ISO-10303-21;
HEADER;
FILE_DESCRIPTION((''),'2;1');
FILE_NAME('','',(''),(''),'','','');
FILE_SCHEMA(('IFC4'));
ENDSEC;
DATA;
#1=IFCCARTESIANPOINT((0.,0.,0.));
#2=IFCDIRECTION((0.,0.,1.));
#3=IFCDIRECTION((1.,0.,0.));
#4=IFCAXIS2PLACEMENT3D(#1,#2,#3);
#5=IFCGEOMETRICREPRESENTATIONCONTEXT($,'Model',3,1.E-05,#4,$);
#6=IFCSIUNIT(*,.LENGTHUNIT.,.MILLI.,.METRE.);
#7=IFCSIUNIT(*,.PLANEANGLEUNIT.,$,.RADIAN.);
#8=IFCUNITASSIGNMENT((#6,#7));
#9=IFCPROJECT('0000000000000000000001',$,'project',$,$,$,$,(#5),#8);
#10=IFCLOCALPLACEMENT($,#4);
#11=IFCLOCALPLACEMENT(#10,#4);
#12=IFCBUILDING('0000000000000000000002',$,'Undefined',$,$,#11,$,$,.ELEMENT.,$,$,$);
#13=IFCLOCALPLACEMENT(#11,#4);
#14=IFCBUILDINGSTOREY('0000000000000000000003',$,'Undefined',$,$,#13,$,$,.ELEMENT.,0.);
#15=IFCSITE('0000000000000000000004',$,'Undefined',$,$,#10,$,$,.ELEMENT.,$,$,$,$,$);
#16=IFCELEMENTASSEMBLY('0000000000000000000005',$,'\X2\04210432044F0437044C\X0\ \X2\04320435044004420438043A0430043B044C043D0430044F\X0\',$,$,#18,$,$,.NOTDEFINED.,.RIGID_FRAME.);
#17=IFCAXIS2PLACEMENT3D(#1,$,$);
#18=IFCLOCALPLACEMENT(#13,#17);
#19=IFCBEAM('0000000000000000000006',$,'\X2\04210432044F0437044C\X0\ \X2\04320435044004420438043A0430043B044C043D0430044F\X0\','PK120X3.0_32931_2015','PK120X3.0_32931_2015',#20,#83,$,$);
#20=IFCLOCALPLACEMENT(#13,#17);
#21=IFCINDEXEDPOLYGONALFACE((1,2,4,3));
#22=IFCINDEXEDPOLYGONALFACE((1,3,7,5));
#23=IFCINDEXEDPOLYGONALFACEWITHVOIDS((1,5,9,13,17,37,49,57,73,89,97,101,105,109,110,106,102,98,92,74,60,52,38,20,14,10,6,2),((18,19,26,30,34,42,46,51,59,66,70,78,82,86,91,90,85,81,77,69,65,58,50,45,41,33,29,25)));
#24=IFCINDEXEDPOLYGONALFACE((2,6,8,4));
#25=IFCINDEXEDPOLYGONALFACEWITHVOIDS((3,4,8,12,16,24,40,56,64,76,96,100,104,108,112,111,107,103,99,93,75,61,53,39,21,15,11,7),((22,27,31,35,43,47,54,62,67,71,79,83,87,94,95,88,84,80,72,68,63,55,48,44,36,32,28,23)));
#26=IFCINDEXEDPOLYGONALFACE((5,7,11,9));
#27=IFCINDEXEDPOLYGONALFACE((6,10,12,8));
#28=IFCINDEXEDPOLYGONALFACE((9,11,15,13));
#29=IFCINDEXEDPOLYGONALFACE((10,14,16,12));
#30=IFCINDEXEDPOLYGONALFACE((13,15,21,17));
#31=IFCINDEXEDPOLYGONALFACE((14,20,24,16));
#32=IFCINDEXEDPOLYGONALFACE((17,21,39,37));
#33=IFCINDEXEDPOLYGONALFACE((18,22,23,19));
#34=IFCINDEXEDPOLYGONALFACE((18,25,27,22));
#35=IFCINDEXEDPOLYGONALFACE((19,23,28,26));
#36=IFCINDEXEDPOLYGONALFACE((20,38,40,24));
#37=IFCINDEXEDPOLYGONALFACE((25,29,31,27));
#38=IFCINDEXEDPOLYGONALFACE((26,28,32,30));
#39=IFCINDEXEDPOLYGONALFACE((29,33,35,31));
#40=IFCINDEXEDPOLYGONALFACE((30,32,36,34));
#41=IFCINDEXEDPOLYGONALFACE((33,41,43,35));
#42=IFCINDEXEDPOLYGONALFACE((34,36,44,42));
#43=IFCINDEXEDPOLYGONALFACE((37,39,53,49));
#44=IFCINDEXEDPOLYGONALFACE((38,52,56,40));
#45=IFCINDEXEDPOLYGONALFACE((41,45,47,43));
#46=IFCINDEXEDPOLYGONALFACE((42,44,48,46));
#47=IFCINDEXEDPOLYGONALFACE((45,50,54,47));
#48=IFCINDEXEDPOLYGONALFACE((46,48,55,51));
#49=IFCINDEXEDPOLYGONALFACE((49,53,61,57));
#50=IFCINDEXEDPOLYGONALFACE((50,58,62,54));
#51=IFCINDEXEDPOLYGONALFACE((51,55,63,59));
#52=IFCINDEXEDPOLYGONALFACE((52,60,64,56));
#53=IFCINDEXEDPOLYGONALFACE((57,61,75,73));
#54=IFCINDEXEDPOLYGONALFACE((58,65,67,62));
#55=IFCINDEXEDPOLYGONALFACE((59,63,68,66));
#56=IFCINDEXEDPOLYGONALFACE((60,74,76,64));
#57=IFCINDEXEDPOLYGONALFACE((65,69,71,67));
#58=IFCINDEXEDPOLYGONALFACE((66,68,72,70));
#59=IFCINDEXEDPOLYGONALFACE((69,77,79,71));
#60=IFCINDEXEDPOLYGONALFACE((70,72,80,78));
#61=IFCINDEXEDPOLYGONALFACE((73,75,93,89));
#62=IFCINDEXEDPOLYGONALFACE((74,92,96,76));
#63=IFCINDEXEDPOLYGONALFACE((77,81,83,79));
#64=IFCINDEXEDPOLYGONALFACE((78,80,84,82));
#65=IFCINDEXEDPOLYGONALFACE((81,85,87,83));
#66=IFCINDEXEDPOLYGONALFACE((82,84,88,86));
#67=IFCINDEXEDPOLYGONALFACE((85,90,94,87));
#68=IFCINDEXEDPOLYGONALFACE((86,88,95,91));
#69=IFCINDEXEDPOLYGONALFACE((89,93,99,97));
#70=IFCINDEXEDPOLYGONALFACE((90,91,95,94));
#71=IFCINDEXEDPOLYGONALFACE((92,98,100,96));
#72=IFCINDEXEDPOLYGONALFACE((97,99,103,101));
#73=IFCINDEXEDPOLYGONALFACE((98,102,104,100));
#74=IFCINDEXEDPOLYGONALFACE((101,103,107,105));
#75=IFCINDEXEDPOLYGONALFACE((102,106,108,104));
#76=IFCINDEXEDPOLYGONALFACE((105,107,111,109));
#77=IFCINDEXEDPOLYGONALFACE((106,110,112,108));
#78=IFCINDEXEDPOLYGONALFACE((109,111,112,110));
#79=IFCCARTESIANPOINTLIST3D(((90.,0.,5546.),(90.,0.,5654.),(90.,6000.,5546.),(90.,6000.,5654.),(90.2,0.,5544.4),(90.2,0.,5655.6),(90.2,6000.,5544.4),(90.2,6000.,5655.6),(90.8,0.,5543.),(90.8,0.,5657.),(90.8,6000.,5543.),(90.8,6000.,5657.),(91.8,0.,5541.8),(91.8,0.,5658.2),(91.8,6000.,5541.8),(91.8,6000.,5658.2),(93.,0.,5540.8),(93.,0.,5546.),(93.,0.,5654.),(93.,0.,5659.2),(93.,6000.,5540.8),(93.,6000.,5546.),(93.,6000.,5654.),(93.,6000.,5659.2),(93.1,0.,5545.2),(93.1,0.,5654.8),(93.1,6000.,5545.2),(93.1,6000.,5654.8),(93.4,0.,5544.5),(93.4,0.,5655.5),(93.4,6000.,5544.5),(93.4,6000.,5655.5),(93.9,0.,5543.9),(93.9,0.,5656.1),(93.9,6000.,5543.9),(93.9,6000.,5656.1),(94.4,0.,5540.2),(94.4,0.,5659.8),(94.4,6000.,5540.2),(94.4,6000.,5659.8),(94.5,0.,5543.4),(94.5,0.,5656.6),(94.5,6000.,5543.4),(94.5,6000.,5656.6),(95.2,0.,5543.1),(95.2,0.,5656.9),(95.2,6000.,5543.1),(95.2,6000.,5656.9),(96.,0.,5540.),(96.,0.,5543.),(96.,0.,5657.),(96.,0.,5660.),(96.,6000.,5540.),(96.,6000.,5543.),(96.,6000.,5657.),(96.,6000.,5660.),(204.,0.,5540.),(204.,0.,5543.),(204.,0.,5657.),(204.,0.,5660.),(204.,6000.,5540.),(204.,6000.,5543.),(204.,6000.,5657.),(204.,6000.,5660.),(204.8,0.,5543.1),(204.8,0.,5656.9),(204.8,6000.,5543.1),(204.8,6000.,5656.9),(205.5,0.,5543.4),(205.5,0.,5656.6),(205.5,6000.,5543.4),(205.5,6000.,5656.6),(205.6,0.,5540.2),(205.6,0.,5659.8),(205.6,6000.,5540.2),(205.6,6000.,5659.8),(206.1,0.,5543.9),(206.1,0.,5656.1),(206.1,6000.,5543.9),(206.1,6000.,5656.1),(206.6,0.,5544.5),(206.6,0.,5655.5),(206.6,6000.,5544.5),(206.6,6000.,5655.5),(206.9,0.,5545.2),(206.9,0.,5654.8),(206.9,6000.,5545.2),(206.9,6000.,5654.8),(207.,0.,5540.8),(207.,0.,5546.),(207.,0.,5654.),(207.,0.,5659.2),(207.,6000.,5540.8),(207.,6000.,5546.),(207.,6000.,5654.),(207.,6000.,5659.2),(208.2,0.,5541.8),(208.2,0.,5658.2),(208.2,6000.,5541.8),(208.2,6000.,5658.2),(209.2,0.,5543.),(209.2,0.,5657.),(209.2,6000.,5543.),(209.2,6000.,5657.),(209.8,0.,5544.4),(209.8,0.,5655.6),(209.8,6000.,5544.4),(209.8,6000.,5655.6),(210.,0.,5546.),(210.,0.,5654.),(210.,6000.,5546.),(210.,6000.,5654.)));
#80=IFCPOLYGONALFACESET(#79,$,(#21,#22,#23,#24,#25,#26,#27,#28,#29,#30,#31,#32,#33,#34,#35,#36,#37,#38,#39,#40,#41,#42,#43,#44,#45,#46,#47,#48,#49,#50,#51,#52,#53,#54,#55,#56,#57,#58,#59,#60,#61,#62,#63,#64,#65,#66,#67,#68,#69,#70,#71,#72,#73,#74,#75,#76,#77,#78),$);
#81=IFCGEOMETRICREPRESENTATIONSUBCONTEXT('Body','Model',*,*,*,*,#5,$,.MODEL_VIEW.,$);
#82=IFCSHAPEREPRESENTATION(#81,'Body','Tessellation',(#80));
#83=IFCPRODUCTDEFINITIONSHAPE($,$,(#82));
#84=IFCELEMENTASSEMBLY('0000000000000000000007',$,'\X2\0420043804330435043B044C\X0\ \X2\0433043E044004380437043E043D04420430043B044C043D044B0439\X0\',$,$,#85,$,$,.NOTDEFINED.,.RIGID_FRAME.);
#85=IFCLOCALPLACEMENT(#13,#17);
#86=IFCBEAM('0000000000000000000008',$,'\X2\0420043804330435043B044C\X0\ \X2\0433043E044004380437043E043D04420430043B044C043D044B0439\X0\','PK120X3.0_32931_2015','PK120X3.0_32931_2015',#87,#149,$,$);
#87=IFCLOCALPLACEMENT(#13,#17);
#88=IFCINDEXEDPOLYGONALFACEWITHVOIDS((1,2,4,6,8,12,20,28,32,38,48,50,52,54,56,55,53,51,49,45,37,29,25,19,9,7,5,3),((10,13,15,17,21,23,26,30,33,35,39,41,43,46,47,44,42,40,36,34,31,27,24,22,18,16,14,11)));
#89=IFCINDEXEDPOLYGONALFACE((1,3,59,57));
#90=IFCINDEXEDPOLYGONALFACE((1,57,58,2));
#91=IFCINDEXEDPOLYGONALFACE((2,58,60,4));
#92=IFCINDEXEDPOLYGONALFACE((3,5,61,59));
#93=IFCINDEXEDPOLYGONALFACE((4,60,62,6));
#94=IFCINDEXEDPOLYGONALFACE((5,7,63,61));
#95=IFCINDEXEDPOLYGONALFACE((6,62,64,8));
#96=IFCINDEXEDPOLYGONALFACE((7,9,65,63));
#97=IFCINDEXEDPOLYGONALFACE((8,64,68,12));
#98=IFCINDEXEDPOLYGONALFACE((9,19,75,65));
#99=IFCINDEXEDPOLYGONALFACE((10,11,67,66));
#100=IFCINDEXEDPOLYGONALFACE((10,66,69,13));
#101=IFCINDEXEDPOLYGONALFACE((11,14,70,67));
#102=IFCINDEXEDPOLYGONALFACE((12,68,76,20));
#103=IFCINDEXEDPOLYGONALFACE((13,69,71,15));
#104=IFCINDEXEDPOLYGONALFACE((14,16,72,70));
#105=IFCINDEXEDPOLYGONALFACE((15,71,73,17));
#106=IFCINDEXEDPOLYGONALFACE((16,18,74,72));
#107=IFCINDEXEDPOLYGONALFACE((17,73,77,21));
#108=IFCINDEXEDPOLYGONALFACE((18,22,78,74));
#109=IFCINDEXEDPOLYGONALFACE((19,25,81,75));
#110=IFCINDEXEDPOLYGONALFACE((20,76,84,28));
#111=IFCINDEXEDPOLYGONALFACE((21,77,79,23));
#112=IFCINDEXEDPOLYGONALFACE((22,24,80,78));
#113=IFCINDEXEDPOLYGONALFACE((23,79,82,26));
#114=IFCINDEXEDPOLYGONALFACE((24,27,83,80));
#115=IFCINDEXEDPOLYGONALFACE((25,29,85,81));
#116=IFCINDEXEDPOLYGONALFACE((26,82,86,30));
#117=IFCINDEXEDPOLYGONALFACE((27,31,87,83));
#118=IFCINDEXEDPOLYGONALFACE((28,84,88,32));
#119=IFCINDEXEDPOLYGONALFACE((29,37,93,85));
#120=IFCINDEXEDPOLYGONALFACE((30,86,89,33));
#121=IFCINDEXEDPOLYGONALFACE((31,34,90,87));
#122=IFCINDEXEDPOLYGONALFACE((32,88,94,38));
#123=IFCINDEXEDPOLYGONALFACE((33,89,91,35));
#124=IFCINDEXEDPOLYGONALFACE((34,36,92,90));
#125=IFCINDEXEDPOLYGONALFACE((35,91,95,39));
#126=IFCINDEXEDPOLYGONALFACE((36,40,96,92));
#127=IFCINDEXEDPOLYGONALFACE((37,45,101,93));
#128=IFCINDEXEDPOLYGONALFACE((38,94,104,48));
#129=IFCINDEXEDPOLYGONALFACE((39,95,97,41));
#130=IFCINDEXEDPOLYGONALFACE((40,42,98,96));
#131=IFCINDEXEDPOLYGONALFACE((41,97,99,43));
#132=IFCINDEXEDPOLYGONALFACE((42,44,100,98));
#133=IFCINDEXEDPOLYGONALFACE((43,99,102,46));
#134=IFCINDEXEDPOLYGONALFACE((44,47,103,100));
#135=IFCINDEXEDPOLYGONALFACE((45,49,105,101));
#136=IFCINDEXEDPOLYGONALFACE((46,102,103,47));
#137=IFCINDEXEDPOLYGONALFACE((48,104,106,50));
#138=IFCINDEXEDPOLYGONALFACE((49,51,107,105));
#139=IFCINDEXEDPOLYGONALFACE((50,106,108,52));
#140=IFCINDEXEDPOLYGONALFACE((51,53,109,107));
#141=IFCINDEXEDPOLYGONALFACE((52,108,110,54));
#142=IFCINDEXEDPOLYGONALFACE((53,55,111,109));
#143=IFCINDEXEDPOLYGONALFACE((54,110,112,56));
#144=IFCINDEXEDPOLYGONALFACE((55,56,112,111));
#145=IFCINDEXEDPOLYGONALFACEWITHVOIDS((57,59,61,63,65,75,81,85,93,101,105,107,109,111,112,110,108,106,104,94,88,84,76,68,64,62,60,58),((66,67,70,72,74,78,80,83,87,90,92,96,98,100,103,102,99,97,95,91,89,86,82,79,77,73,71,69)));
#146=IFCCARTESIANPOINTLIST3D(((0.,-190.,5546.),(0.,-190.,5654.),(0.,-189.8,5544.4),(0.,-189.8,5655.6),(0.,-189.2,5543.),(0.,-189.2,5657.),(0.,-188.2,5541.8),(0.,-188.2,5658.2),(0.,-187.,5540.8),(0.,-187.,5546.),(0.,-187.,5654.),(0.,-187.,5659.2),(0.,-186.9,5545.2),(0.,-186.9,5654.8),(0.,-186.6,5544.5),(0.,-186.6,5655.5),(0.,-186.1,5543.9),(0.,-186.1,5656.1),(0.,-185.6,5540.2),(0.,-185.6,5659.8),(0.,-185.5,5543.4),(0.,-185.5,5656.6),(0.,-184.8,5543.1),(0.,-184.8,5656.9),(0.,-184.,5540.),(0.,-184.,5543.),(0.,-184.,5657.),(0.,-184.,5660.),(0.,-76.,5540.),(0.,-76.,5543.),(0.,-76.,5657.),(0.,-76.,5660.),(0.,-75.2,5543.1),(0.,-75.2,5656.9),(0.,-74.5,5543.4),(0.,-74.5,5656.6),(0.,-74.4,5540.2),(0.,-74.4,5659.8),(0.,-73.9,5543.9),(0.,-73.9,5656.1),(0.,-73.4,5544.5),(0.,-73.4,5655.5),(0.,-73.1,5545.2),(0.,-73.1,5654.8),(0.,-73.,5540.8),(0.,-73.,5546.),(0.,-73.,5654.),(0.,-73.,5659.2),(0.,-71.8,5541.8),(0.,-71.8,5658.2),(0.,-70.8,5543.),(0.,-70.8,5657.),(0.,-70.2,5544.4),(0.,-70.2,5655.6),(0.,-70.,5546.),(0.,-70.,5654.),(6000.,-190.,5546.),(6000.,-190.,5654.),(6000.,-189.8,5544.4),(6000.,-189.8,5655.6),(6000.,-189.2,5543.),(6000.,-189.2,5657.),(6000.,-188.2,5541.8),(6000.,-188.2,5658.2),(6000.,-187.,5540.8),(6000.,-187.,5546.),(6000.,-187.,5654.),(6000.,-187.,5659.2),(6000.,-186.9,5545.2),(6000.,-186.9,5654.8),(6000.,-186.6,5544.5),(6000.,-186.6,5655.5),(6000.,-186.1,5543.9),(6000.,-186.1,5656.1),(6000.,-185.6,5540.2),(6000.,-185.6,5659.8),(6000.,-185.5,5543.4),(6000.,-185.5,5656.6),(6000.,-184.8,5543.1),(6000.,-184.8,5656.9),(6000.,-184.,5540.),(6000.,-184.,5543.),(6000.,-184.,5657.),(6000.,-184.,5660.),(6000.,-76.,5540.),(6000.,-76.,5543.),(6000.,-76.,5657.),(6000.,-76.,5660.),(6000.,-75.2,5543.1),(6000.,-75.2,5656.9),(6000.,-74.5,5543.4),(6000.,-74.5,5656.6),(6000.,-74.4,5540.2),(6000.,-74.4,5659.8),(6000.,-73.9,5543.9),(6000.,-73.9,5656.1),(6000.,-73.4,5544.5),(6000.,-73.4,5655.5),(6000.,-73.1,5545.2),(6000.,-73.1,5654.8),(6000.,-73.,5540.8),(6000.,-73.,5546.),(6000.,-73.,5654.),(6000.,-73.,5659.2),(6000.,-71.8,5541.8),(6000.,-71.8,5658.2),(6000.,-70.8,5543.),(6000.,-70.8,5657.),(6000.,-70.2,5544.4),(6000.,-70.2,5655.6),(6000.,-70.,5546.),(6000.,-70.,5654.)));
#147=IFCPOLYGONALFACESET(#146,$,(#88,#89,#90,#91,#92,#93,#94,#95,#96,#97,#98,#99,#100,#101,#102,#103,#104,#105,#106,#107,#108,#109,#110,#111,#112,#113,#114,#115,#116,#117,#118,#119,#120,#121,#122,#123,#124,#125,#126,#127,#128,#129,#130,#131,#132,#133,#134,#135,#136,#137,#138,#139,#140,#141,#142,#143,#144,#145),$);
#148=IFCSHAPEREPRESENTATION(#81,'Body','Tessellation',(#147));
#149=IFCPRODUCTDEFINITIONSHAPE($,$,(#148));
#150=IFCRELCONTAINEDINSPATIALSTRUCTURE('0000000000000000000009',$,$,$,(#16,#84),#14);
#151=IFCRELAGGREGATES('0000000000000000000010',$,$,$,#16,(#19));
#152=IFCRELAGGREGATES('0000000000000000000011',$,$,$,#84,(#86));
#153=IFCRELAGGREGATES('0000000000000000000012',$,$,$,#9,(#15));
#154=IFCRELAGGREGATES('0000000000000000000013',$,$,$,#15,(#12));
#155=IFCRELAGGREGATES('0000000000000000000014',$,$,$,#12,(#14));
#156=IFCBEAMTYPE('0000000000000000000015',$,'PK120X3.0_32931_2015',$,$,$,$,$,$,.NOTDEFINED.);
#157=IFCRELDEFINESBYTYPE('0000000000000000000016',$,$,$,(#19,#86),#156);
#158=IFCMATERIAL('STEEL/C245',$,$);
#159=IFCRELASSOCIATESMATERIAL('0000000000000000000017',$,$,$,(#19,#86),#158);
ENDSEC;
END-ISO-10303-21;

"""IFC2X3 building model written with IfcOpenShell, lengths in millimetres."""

from ifc_helpers import new_model, si_unit, frame, origin_with_axes, origin_2d_with_axis, place, context, subcontext, project, spatial, hollow_rectangle, extrude, material, type_object, element, aggregate, save


model = new_model("IFC2X3")

# Units and contexts
model_context = context("Model", 3, precision=1e-05, world=origin_with_axes())
body_context = subcontext(model_context, "Body", "Model", "MODEL_VIEW")
ifc_project = project(units=[si_unit("LENGTHUNIT", "METRE", prefix="MILLI"), si_unit("PLANEANGLEUNIT", "RADIAN")], contexts=[model_context])

# Site, building, storey
site_placement = place(None, origin_with_axes())
site = spatial("IfcSite", under=ifc_project, at=site_placement, Name="Undefined", CompositionType="ELEMENT")
building_placement = place(site_placement, origin_with_axes())
building = spatial("IfcBuilding", under=site, at=building_placement, Name="Undefined", CompositionType="ELEMENT")
storey_placement = place(building_placement, origin_with_axes())
storey = spatial("IfcBuildingStorey", under=building, at=storey_placement, Name="Undefined", CompositionType="ELEMENT", Elevation=0.0)

# Shared definitions
ifc_material_1 = material(Name="STEEL/C245")

# Element assemblies, beams
assembly_1_placement = place(storey_placement, origin_with_axes())
assembly_1 = element("IfcElementAssembly", 1, at=assembly_1_placement, inside=storey, Name="Связь вертикальная", AssemblyPlace="NOTDEFINED", PredefinedType="RIGID_FRAME")
beam_type_1 = type_object("IfcBeamType", Name="PK120X3.0_32931_2015", PredefinedType="NOTDEFINED")
beam_1_placement = place(assembly_1_placement, frame((150.0, 6000.0, 5600.0), z_axis=(0.0, 0.0, 1.0), x_axis=(0.0, -1.0, 0.0)))
beam_1 = element("IfcBeam", 2, at=beam_1_placement, type_object=beam_type_1, material=ifc_material_1, Name="Связь вертикальная", Description="PK120X3.0_32931_2015", ObjectType="PK120X3.0_32931_2015", context=body_context, shape_type="SweptSolid", body=[
    extrude(hollow_rectangle(XDim=120.0, YDim=120.0, WallThickness=3.0, InnerFilletRadius=3.0, OuterFilletRadius=6.0, at=origin_2d_with_axis()), frame((6000.0, 0.0, 0.0), z_axis=(-1.0, 0.0, 0.0), x_axis=(0.0, -1.0, 0.0)), (0.0, 0.0, 1.0), 6000.0),
])
aggregate(assembly_1, [beam_1])
assembly_2_placement = place(storey_placement, origin_with_axes())
assembly_2 = element("IfcElementAssembly", 3, at=assembly_2_placement, inside=storey, Name="Ригель горизонтальный", AssemblyPlace="NOTDEFINED", PredefinedType="RIGID_FRAME")
beam_2_placement = place(assembly_2_placement, frame((6000.0, -130.0, 5600.0), z_axis=(0.0, 0.0, 1.0), x_axis=(-1.0, 0.0, 0.0)))
beam_2 = element("IfcBeam", 4, at=beam_2_placement, type_object=beam_type_1, material=ifc_material_1, Name="Ригель горизонтальный", Description="PK120X3.0_32931_2015", ObjectType="PK120X3.0_32931_2015", context=body_context, shape_type="SweptSolid", body=[
    extrude(hollow_rectangle(XDim=120.0, YDim=120.0, WallThickness=3.0, InnerFilletRadius=3.0, OuterFilletRadius=6.0, at=origin_2d_with_axis()), frame((6000.0, 0.0, 0.0), z_axis=(-1.0, 0.0, 0.0), x_axis=(0.0, -1.0, 0.0)), (0.0, 0.0, 1.0), 6000.0),
])
aggregate(assembly_2, [beam_2])

save(model, "model.ifc")
